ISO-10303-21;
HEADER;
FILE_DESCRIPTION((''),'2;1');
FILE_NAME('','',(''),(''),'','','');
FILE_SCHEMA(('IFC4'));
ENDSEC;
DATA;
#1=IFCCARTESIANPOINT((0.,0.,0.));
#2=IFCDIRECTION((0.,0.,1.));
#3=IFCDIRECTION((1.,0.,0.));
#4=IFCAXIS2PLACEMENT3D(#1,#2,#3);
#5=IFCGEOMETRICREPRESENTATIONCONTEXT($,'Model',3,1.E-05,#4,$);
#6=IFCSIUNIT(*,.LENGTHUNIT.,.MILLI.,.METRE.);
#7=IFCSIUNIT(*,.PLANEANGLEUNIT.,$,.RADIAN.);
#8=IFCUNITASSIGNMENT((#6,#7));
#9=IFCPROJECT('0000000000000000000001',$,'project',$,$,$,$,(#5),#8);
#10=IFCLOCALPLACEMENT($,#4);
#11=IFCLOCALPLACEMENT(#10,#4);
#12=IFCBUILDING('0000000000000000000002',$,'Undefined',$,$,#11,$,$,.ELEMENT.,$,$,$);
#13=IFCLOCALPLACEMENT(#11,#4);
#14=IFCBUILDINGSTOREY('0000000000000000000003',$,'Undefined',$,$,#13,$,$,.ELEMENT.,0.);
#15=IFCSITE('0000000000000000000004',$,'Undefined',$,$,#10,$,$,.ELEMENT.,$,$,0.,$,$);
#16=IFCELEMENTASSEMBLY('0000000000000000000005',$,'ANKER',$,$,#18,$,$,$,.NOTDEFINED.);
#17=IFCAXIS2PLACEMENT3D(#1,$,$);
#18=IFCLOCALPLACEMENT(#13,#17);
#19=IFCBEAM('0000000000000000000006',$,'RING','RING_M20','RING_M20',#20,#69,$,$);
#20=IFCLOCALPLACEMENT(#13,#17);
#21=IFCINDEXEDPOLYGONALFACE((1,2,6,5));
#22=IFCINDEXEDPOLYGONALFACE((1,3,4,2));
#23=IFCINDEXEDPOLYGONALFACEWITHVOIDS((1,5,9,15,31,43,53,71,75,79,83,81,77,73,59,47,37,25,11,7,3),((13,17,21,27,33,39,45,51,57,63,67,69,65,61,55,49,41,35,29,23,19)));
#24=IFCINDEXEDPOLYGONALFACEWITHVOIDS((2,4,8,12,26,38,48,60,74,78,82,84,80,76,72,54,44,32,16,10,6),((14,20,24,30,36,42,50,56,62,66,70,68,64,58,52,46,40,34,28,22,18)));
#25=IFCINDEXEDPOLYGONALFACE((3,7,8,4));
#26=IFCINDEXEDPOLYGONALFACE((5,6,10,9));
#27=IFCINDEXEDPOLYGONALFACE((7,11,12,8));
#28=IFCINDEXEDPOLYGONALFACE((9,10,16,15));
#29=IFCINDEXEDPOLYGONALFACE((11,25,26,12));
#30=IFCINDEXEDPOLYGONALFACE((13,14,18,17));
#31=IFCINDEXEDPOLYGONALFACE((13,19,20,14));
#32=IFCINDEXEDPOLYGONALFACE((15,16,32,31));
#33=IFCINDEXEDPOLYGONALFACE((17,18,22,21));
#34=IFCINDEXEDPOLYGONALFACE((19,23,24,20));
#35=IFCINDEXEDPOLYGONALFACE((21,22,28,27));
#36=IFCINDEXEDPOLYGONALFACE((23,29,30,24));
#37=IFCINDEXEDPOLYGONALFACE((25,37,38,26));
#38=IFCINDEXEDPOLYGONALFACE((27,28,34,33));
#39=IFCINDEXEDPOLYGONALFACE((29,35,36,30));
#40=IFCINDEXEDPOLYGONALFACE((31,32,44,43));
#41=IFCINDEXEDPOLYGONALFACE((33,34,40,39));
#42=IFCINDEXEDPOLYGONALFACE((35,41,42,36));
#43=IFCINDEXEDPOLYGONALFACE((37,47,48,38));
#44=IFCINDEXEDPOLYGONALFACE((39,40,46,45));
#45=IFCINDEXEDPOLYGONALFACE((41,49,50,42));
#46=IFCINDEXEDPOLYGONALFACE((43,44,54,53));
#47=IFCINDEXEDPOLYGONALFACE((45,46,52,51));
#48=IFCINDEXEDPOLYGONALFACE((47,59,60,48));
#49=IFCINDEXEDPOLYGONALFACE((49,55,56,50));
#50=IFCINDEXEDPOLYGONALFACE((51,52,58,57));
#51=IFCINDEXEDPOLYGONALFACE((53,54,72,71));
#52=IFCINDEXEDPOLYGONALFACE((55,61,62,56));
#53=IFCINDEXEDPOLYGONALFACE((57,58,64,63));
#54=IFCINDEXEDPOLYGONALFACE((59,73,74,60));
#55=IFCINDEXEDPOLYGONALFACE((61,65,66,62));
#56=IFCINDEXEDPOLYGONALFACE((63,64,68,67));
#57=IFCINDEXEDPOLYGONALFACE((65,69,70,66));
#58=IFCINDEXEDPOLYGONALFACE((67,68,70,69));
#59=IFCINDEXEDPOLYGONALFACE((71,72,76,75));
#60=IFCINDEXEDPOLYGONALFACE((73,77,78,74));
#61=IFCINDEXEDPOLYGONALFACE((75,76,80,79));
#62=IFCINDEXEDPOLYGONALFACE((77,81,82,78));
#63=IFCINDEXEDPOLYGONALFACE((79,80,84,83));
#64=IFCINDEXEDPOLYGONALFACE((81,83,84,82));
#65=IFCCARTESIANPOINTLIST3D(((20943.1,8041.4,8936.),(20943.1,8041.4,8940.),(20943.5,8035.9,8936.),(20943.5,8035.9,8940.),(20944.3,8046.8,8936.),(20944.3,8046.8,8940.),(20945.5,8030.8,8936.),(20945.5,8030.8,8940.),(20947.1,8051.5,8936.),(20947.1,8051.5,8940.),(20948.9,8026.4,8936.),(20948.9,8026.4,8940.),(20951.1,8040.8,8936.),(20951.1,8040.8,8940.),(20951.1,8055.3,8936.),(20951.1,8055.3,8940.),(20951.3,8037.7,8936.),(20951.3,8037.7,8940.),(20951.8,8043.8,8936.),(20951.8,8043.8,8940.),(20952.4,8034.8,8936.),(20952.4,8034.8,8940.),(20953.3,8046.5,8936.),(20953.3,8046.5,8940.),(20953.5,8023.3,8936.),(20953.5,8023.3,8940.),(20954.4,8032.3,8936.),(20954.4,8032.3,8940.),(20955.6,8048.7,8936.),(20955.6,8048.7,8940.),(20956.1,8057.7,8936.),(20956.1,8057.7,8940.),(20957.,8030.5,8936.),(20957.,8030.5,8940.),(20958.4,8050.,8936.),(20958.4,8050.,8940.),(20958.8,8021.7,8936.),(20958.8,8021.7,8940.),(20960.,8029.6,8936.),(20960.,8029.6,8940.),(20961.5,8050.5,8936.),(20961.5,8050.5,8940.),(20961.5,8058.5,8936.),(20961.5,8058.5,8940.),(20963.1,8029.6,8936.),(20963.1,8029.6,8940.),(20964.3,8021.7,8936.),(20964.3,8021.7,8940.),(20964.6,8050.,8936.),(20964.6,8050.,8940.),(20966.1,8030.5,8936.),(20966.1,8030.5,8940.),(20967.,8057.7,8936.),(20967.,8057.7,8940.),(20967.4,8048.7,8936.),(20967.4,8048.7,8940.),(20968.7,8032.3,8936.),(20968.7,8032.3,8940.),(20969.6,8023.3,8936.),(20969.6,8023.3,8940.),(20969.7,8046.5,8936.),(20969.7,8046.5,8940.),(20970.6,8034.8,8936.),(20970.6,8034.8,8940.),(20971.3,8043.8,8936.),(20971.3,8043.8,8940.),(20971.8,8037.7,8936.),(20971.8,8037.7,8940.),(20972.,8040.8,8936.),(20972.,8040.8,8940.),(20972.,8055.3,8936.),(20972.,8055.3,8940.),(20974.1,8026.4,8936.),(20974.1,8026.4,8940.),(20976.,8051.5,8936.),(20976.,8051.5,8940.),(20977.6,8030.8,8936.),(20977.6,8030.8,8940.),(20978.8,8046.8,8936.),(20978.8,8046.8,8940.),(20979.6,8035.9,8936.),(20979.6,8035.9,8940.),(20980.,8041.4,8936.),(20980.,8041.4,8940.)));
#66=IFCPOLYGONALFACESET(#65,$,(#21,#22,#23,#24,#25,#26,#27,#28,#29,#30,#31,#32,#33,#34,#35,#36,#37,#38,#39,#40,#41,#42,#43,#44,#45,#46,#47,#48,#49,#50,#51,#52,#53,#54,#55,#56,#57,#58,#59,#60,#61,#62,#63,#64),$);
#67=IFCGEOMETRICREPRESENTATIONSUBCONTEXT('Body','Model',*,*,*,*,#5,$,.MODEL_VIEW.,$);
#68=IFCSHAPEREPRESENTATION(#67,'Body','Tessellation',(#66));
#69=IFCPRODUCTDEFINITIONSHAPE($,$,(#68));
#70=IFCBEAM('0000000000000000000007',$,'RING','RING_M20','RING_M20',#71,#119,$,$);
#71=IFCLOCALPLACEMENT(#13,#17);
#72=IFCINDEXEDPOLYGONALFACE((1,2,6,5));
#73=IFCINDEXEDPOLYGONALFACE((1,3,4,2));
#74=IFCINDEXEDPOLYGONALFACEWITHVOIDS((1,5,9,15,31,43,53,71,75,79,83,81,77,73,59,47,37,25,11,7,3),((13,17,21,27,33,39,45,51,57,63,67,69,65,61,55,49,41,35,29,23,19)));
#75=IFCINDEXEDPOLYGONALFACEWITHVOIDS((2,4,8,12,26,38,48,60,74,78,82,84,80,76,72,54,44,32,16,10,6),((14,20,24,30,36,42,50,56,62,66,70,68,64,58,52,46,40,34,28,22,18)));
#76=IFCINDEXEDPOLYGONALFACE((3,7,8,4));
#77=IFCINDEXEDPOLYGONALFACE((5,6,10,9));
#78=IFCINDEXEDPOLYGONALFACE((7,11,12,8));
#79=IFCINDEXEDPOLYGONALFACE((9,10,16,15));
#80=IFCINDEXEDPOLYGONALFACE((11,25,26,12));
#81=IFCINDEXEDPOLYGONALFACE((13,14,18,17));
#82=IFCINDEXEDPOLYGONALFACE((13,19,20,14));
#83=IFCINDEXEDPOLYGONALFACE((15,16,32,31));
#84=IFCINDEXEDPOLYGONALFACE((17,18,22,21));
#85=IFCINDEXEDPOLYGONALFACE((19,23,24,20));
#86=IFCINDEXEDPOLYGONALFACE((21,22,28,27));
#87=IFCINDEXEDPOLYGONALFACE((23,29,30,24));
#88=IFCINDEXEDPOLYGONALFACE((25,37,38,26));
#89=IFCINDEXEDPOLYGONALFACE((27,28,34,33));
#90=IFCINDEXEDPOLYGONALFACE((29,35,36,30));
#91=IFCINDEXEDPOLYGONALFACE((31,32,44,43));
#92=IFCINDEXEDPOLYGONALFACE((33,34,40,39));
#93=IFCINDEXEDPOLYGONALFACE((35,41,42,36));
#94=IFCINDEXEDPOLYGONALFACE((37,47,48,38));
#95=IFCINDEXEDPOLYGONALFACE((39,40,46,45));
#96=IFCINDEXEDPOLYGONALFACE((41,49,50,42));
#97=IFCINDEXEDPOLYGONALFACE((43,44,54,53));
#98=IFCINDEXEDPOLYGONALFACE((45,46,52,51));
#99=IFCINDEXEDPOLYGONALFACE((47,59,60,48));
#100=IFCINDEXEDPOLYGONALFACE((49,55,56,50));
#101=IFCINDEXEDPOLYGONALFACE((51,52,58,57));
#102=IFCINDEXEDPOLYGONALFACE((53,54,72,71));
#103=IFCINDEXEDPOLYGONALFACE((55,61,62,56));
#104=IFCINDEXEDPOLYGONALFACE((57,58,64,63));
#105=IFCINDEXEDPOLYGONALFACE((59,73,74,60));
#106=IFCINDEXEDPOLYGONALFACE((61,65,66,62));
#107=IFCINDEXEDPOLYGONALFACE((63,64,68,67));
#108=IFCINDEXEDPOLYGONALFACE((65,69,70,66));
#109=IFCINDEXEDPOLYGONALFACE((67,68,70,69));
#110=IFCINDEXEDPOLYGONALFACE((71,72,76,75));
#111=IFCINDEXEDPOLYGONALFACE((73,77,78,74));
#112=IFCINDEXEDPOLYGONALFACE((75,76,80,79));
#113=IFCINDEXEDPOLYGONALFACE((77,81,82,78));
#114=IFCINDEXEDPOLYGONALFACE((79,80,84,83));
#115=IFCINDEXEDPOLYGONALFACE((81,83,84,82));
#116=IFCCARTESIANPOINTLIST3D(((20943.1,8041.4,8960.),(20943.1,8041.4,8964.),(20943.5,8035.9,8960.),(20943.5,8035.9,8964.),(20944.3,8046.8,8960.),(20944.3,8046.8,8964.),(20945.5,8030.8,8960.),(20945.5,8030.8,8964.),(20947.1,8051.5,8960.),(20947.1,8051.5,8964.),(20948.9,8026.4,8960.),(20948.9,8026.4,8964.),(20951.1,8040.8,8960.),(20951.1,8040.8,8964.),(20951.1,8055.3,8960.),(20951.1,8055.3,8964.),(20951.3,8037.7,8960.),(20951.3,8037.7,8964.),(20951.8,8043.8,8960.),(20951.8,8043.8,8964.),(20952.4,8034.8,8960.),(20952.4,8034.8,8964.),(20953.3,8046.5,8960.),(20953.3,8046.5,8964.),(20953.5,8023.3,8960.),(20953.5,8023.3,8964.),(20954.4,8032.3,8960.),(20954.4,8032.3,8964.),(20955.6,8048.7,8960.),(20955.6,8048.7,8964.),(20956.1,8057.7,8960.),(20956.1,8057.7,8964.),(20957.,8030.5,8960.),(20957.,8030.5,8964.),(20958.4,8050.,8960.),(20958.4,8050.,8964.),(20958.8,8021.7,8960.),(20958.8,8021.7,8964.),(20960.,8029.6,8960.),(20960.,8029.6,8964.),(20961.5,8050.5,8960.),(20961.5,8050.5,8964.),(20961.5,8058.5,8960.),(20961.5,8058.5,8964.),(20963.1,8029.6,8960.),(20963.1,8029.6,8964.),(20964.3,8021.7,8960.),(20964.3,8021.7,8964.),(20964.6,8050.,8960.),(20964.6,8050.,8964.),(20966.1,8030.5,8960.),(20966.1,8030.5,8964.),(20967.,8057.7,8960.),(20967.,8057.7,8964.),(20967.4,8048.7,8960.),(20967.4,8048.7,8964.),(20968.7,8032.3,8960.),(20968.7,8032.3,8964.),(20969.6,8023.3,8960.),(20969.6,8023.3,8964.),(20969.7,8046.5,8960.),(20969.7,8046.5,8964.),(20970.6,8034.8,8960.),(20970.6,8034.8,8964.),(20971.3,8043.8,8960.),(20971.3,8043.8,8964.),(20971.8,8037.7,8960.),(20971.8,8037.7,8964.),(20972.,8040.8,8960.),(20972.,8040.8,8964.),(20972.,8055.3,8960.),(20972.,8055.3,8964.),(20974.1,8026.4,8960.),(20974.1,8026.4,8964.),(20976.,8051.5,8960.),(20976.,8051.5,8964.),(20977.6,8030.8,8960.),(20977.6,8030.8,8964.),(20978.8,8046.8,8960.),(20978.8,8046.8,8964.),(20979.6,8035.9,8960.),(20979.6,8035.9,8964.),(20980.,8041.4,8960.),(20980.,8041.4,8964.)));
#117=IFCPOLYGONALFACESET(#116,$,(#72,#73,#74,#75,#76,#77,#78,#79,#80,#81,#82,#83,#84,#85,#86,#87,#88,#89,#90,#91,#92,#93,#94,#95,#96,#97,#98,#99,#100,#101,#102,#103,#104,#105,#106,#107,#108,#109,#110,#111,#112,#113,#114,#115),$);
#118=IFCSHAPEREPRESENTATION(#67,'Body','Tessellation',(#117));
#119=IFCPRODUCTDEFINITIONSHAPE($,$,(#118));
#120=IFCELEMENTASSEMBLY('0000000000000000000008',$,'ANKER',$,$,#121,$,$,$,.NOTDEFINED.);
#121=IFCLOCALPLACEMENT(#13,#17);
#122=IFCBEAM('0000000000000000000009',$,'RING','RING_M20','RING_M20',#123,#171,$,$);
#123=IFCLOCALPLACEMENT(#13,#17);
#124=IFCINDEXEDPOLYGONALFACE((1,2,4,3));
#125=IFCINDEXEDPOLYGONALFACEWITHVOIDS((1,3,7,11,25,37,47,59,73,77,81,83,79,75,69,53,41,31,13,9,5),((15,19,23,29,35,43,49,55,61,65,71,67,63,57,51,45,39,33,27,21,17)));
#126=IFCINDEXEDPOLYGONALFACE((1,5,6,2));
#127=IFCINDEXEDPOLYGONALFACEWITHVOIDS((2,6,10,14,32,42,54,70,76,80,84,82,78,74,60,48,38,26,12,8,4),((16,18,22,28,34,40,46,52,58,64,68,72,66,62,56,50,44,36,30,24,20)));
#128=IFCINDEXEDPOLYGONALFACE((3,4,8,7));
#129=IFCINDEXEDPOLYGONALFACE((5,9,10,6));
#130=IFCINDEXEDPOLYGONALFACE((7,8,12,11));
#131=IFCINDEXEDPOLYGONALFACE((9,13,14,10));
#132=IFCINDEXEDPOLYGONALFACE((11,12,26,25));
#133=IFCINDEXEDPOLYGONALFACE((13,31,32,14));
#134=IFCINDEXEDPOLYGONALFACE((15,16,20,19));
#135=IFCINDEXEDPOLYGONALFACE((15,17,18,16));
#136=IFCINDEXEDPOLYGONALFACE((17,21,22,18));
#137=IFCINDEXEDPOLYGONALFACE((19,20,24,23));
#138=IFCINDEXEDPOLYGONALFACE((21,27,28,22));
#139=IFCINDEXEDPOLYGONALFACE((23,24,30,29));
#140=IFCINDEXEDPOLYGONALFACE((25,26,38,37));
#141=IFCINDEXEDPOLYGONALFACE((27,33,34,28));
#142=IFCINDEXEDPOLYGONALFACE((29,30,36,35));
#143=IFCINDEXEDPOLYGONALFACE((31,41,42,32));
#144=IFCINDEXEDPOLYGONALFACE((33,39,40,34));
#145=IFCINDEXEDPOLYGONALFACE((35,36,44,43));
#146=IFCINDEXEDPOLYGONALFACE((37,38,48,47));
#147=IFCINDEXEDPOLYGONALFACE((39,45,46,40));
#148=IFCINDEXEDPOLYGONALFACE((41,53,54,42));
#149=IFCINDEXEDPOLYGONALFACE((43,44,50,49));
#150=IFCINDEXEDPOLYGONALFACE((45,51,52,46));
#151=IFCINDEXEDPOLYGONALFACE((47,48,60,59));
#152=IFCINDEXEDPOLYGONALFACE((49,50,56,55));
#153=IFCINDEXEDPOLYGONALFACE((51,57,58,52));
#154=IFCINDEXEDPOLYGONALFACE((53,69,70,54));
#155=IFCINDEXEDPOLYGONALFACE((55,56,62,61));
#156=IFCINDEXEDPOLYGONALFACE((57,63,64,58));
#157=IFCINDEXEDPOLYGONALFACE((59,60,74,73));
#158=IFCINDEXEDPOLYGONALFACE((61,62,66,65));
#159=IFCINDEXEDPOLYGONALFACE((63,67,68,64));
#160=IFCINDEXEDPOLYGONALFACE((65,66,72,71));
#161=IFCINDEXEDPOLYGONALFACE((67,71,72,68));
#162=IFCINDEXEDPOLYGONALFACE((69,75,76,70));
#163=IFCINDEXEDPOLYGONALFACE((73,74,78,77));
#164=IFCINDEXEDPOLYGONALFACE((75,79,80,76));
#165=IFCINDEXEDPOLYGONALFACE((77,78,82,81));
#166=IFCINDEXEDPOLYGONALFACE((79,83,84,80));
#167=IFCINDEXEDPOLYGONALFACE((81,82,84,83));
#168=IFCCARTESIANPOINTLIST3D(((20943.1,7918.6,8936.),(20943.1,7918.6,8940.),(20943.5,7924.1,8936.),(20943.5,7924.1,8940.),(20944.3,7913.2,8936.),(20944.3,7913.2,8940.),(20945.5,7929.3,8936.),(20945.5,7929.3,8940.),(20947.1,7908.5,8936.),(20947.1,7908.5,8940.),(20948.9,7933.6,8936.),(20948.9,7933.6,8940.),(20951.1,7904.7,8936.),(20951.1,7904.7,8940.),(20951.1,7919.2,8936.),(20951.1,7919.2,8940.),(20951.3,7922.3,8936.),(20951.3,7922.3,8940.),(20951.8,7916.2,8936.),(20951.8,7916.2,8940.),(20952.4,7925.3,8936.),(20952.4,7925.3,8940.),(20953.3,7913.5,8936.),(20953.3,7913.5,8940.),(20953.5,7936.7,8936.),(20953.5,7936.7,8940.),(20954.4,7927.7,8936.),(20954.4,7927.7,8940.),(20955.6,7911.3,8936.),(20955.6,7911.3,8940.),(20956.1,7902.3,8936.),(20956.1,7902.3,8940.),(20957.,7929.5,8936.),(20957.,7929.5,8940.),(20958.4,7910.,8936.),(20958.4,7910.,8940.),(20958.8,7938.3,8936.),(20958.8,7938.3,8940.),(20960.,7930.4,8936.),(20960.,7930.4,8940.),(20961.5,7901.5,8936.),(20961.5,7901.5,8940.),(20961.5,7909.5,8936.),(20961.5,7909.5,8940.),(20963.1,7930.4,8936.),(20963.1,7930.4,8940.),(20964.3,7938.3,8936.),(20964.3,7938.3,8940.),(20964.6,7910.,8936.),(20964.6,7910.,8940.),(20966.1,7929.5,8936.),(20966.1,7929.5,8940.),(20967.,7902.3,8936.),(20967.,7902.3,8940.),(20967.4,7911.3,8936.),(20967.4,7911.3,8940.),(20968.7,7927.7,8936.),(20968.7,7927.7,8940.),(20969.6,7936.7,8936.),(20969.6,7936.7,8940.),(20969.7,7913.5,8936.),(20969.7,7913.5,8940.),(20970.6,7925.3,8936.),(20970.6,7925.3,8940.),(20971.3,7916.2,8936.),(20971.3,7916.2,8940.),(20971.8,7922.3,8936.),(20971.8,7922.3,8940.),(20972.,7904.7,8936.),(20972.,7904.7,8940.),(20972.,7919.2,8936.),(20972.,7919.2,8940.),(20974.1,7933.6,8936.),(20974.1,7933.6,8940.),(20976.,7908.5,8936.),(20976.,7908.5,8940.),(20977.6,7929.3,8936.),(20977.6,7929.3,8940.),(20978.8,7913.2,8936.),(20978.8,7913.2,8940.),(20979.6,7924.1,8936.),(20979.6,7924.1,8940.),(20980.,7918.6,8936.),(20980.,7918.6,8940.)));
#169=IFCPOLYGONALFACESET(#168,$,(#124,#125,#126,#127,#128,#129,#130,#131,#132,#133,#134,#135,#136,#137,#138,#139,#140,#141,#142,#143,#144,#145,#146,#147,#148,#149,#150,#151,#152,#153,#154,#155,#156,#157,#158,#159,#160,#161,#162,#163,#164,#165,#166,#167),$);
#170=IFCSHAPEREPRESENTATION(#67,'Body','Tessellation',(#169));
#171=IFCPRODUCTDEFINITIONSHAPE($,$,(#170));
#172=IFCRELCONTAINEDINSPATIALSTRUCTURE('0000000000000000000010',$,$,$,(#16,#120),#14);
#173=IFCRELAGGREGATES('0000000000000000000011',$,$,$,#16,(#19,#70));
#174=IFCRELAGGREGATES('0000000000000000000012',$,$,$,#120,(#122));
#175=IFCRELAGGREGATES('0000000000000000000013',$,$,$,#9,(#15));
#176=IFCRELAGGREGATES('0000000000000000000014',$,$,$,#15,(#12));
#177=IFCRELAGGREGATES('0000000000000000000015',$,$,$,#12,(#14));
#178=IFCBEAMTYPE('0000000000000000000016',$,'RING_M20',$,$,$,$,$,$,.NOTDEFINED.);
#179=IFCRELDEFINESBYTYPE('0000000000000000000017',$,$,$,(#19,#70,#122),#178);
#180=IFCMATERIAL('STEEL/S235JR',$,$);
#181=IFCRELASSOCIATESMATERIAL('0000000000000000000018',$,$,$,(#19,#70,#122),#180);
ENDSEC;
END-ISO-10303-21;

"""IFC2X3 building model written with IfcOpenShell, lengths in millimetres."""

from ifc_helpers import new_model, si_unit, frame, origin_with_axes, origin_2d_with_axis, place, context, subcontext, project, spatial, hollow_circle, extrude, material, type_object, element, aggregate, save


model = new_model("IFC2X3")

# Units and contexts
model_context = context("Model", 3, precision=1e-05, world=origin_with_axes())
body_context = subcontext(model_context, "Body", "Model", "MODEL_VIEW")
ifc_project = project(units=[si_unit("LENGTHUNIT", "METRE", prefix="MILLI"), si_unit("PLANEANGLEUNIT", "RADIAN")], contexts=[model_context])

# Site, building, storey
site_placement = place(None, origin_with_axes())
site = spatial("IfcSite", under=ifc_project, at=site_placement, Name="Undefined", CompositionType="ELEMENT", RefElevation=0.0)
building_placement = place(site_placement, origin_with_axes())
building = spatial("IfcBuilding", under=site, at=building_placement, Name="Undefined", CompositionType="ELEMENT")
storey_placement = place(building_placement, origin_with_axes())
storey = spatial("IfcBuildingStorey", under=building, at=storey_placement, Name="Undefined", CompositionType="ELEMENT", Elevation=0.0)

# Shared definitions
ifc_material = material(Name="STEEL/S235JR")

# Element assemblies, beams
assembly_1_placement = place(storey_placement, frame((20961.5, 8040.0, 9010.0), z_axis=(0.0, 1.0, 0.0), x_axis=(0.0, 0.0, -1.0)))
assembly_1 = element("IfcElementAssembly", 1, at=assembly_1_placement, inside=storey, Name="ANKER", PredefinedType="NOTDEFINED")
beam_type_1 = type_object("IfcBeamType", Name="RING_M20", PredefinedType="NOTDEFINED")
beam_1_placement = place(storey_placement, frame((20961.5, 8040.0, 8940.0), z_axis=(-1.0, 0.0, 0.0), x_axis=(0.0, 0.0, -1.0)))
beam_1 = element("IfcBeam", 2, at=beam_1_placement, type_object=beam_type_1, material=ifc_material, Name="RING", Description="RING_M20", ObjectType="RING_M20", context=body_context, shape_type="SweptSolid", body=[
    extrude(hollow_circle(Radius=18.5, WallThickness=8.0, at=origin_2d_with_axis()), frame((4.0, 0.0, 0.0), z_axis=(-1.0, 0.0, 0.0), x_axis=(0.0, -1.0, 0.0)), (0.0, 0.0, 1.0), 4.0),
])
beam_2_placement = place(storey_placement, frame((20961.5, 8040.0, 8964.0), z_axis=(-1.0, 0.0, 0.0), x_axis=(0.0, 0.0, -1.0)))
beam_2 = element("IfcBeam", 3, at=beam_2_placement, type_object=beam_type_1, material=ifc_material, Name="RING", Description="RING_M20", ObjectType="RING_M20", context=body_context, shape_type="SweptSolid", body=[
    extrude(hollow_circle(Radius=18.5, WallThickness=8.0, at=origin_2d_with_axis()), frame((4.0, 0.0, 0.0), z_axis=(-1.0, 0.0, 0.0), x_axis=(0.0, -1.0, 0.0)), (0.0, 0.0, 1.0), 4.0),
])
aggregate(assembly_1, [beam_1, beam_2])
assembly_2_placement = place(storey_placement, frame((20961.5, 7920.0, 9010.0), z_axis=(0.0, 1.0, 0.0), x_axis=(0.0, 0.0, -1.0)))
assembly_2 = element("IfcElementAssembly", 4, at=assembly_2_placement, inside=storey, Name="ANKER", PredefinedType="NOTDEFINED")
beam_3_placement = place(storey_placement, frame((20961.5, 7920.0, 8940.0), z_axis=(1.0, 0.0, 0.0), x_axis=(0.0, 0.0, -1.0)))
beam_3 = element("IfcBeam", 5, at=beam_3_placement, type_object=beam_type_1, material=ifc_material, Name="RING", Description="RING_M20", ObjectType="RING_M20", context=body_context, shape_type="SweptSolid", body=[
    extrude(hollow_circle(Radius=18.5, WallThickness=8.0, at=origin_2d_with_axis()), frame((4.0, 0.0, 0.0), z_axis=(-1.0, 0.0, 0.0), x_axis=(0.0, -1.0, 0.0)), (0.0, 0.0, 1.0), 4.0),
])
aggregate(assembly_2, [beam_3])

save(model, "model.ifc")
